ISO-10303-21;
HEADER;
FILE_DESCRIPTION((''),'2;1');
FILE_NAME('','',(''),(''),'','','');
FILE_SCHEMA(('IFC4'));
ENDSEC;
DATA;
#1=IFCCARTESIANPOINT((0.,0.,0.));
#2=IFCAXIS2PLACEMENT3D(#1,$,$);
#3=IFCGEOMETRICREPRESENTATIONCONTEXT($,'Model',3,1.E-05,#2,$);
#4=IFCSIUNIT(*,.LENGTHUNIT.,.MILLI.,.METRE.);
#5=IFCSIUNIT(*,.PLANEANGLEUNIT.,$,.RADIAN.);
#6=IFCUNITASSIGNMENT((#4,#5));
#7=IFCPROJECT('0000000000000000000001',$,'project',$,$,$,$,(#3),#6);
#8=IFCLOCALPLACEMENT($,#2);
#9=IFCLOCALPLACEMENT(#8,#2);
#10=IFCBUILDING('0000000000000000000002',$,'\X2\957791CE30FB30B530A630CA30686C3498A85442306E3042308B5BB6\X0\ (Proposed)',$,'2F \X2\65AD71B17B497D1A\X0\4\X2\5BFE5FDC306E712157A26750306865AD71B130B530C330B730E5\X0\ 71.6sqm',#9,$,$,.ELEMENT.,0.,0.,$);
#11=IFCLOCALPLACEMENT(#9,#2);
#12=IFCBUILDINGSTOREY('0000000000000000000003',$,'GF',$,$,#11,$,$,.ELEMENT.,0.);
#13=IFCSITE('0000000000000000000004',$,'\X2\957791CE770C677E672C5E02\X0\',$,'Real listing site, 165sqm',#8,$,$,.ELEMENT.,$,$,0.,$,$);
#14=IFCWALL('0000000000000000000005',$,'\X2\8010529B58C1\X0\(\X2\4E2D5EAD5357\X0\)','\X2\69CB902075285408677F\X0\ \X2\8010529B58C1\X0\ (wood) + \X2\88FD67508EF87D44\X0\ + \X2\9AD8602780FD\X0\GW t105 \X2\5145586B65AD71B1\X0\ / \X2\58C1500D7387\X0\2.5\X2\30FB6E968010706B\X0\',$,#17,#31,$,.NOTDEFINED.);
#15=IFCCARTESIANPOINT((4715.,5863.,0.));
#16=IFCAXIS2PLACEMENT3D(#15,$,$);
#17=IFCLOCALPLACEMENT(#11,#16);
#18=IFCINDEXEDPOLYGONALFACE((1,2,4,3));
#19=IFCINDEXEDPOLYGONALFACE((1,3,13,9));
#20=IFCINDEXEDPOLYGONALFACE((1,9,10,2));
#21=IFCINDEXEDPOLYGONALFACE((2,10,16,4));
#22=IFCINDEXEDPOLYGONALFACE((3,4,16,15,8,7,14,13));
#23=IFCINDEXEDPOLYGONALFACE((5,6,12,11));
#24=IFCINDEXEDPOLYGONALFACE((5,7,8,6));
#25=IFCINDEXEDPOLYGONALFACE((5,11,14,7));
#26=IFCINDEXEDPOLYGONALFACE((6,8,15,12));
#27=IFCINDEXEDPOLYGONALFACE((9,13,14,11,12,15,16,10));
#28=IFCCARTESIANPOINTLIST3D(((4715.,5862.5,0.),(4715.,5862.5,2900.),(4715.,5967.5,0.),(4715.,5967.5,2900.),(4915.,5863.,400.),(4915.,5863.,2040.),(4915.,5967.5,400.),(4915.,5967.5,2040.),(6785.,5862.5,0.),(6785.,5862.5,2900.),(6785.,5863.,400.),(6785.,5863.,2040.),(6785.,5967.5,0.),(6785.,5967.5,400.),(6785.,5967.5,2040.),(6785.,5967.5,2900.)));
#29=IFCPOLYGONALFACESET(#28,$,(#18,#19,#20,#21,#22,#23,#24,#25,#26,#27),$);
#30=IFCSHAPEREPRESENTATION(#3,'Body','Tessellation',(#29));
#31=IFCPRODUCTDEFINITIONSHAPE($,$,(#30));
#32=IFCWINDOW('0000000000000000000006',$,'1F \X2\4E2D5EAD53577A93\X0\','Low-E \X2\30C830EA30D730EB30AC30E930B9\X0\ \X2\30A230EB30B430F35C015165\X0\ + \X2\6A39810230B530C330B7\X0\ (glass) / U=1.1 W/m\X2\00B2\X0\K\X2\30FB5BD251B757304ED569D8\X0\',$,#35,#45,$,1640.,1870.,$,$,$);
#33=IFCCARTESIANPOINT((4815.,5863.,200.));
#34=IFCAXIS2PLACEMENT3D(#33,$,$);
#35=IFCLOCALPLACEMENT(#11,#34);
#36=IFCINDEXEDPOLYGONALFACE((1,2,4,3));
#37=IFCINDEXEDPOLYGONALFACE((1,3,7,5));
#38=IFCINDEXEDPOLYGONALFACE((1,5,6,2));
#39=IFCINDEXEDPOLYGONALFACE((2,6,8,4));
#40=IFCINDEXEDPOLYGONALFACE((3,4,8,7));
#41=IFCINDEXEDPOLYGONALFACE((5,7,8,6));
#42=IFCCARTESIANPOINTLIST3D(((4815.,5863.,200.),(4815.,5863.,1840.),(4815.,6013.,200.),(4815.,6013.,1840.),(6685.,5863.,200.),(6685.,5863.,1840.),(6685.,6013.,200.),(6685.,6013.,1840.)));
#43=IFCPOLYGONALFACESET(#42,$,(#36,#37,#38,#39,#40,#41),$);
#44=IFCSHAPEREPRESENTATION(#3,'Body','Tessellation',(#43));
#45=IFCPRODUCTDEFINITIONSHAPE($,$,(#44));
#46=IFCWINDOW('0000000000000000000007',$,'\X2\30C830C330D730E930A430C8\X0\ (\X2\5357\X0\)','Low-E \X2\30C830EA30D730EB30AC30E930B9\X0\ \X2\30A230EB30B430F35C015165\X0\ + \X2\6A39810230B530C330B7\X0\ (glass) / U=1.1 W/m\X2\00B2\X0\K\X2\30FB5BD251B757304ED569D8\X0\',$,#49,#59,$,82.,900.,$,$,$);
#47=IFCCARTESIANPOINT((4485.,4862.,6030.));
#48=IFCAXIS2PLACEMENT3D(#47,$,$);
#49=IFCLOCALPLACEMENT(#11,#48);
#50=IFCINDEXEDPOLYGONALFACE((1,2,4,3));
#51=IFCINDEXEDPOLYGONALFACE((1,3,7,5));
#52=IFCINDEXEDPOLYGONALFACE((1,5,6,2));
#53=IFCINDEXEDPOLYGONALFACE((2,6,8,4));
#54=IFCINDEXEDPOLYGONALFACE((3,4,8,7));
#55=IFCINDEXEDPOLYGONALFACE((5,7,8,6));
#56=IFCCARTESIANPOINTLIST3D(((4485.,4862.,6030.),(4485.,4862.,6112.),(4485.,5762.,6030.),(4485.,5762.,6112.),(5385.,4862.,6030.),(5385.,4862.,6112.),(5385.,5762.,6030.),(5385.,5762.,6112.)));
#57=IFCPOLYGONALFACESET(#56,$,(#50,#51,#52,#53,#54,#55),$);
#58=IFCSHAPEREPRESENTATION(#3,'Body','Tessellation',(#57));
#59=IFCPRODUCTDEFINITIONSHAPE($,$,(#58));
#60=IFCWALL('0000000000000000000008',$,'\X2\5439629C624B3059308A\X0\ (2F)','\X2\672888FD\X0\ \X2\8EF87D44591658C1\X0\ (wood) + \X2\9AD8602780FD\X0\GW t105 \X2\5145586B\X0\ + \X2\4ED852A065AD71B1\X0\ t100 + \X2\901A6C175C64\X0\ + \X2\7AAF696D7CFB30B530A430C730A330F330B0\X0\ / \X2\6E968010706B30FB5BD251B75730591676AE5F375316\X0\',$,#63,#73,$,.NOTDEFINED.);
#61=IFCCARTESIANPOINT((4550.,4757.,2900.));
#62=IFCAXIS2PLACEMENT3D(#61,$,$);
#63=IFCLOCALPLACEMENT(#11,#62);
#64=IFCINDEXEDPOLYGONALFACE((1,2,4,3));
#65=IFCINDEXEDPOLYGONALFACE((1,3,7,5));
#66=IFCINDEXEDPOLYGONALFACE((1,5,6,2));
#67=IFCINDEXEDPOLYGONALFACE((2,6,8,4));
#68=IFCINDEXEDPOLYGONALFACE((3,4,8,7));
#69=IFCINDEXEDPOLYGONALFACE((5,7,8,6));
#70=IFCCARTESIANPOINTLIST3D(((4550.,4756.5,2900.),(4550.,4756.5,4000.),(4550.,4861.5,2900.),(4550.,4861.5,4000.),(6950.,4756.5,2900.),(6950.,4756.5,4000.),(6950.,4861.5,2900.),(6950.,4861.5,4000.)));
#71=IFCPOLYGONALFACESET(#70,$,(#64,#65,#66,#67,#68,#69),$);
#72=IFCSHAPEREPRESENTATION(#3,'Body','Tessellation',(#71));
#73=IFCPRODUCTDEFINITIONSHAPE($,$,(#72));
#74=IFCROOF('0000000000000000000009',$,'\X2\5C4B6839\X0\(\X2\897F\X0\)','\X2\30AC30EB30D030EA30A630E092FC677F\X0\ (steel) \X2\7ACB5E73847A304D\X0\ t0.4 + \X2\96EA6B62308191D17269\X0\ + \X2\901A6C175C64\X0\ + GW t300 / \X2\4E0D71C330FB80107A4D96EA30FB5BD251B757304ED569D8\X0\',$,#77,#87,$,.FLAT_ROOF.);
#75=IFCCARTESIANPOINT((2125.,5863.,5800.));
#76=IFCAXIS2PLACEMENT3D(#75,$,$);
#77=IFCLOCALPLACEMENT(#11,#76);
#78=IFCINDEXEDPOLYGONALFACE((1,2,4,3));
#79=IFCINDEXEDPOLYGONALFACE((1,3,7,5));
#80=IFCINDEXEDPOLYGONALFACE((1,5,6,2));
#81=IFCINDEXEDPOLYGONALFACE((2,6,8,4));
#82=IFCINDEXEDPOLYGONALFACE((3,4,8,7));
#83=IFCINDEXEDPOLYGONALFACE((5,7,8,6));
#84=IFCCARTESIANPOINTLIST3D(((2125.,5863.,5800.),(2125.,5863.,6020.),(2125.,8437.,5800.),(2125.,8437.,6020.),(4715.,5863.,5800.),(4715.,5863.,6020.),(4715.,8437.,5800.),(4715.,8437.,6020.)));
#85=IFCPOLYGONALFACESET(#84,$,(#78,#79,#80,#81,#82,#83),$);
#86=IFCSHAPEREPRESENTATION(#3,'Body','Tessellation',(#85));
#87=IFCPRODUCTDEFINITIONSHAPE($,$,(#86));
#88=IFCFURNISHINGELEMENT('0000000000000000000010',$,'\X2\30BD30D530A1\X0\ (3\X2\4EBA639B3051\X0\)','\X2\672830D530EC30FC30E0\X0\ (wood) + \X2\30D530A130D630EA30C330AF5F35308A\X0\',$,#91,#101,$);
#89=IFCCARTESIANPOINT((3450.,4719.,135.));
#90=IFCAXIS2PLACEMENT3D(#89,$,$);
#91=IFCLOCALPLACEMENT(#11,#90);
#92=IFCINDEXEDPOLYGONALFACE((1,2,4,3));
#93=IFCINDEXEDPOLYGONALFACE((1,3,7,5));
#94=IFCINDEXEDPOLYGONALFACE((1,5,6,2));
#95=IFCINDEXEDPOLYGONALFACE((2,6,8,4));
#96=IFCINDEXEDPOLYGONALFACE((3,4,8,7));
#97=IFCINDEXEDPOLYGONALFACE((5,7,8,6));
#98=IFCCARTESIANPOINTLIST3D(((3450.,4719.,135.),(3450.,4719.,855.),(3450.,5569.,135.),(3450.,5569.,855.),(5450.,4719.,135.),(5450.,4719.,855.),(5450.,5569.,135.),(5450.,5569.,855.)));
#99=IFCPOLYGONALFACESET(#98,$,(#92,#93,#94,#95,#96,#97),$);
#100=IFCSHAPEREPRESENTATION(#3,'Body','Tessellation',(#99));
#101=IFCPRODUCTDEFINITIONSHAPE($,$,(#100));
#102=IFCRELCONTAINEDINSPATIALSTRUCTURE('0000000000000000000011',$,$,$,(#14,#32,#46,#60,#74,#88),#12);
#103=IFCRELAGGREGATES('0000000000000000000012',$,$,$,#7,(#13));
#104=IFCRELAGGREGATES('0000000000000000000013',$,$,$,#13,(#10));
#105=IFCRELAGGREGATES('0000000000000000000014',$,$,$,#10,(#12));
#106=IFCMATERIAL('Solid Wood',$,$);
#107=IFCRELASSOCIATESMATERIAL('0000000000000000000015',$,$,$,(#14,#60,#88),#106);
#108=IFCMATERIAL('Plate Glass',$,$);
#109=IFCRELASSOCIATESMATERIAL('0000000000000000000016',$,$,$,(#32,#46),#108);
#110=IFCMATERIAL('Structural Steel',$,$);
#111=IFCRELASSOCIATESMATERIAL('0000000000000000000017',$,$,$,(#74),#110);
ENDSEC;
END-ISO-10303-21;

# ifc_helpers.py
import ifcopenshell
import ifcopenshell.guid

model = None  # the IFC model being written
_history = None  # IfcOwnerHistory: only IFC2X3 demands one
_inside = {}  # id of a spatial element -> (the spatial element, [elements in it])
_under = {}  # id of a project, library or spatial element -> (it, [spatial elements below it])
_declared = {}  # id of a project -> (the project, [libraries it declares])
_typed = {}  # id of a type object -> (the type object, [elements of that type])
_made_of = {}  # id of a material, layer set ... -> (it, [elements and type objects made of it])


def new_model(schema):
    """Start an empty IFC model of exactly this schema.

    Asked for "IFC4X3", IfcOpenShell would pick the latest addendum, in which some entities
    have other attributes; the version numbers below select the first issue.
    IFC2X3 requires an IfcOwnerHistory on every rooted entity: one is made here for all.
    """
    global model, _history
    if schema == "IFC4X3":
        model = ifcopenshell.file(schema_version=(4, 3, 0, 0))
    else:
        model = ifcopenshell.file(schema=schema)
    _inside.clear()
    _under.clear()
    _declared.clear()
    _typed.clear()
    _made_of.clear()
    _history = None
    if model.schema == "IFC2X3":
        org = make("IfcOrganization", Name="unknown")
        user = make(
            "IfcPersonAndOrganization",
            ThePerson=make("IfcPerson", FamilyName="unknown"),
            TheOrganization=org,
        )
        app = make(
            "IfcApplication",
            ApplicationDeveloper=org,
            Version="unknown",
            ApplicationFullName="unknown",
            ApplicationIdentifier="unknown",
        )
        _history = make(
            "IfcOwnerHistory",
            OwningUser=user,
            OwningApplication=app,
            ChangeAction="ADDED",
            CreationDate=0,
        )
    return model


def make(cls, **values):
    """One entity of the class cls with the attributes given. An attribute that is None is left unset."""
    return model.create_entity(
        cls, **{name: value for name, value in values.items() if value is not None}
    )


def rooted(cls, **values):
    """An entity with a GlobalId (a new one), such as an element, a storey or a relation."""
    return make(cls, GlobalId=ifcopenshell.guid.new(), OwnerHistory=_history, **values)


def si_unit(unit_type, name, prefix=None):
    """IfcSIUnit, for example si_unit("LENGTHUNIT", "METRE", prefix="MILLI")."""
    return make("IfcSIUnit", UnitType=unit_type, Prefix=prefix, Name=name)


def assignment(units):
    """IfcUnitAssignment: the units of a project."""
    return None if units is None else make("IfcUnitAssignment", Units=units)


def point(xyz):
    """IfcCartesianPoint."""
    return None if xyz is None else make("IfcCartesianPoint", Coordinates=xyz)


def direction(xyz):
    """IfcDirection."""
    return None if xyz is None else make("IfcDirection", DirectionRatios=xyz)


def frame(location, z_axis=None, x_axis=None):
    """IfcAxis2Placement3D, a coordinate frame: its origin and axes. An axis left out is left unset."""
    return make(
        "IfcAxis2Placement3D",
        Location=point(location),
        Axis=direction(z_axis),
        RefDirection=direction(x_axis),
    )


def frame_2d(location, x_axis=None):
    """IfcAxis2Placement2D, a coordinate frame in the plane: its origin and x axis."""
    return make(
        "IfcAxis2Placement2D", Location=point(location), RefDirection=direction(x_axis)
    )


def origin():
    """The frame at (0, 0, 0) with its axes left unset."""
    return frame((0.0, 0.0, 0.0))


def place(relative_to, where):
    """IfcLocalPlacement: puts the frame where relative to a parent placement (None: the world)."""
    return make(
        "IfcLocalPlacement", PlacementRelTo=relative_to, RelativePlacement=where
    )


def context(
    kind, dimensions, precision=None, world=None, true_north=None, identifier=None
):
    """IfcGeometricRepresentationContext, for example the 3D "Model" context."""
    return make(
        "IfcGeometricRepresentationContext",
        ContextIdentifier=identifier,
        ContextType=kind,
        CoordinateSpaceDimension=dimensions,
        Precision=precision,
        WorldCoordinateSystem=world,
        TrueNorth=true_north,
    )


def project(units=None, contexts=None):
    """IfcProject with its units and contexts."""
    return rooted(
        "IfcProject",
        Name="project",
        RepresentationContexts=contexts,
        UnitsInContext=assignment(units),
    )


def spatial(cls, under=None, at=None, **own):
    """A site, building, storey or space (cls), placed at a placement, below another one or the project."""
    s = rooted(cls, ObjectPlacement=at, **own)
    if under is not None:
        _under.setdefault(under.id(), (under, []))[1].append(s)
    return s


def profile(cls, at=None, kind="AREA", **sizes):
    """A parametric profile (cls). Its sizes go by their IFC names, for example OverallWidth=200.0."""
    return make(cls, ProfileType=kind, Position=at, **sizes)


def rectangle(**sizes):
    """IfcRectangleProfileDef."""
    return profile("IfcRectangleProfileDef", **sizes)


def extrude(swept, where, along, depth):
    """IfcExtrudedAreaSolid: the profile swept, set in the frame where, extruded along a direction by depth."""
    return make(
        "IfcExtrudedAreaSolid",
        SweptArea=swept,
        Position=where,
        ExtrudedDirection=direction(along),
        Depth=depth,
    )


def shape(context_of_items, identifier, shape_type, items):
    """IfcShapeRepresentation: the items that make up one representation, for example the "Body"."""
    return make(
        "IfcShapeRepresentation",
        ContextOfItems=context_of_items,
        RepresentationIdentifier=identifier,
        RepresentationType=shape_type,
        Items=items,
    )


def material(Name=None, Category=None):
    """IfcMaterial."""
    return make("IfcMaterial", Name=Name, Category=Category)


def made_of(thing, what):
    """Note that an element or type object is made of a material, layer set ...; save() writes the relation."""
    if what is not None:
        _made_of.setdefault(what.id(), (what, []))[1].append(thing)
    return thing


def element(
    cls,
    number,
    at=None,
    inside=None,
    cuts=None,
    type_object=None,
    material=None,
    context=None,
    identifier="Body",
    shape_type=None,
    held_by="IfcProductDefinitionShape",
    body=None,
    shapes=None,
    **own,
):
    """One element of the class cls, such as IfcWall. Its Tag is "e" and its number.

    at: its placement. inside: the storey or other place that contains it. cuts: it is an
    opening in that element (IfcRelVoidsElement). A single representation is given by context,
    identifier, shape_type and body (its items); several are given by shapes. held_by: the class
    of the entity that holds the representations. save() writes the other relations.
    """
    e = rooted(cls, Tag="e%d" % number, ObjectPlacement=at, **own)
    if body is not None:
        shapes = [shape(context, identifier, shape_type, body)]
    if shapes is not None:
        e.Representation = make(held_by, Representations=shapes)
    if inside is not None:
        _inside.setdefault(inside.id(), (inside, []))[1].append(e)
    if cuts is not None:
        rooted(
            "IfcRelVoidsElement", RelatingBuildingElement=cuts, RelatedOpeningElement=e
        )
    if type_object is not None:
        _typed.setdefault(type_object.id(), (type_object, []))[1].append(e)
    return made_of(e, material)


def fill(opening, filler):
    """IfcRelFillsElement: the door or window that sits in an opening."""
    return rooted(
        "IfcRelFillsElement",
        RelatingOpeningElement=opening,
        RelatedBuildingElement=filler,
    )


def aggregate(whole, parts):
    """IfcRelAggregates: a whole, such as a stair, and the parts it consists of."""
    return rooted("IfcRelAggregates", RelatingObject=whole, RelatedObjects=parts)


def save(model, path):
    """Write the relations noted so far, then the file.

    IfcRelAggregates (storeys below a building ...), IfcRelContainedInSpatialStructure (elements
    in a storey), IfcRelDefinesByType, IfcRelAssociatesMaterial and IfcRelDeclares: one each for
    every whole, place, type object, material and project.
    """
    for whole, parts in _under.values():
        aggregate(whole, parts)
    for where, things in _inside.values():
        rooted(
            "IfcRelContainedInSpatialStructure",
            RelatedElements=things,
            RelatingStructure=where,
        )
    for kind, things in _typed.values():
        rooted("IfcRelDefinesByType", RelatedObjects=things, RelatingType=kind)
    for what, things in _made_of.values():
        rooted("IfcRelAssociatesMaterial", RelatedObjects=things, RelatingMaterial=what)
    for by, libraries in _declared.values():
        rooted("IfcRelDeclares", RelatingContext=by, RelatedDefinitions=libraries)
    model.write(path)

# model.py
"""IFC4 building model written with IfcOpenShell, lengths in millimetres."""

from ifc_helpers import new_model, si_unit, frame, frame_2d, origin, place, context, project, spatial, rectangle, extrude, material, element, fill, save


model = new_model("IFC4")

# Units and contexts
model_context = context("Model", 3, precision=1e-05, world=origin())
ifc_project = project(units=[si_unit("LENGTHUNIT", "METRE", prefix="MILLI"), si_unit("PLANEANGLEUNIT", "RADIAN")], contexts=[model_context])

# Site, building, storey
site_placement = place(None, origin())
site = spatial("IfcSite", under=ifc_project, at=site_placement, Name="長野県松本市", ObjectType="Real listing site, 165sqm", CompositionType="ELEMENT", RefElevation=0.0)
building_placement = place(site_placement, origin())
building = spatial("IfcBuilding", under=site, at=building_placement, Name="長野・サウナと水風呂のある家 (Proposed)", ObjectType="2F 断熱等級4対応の無垢材と断熱サッシュ 71.6sqm", CompositionType="ELEMENT", ElevationOfRefHeight=0.0, ElevationOfTerrain=0.0)
storey_placement = place(building_placement, origin())
storey = spatial("IfcBuildingStorey", under=building, at=storey_placement, Name="GF", CompositionType="ELEMENT", Elevation=0.0)

# Shared definitions
ifc_material_1 = material(Name="Solid Wood")

# Wall, opening, window
wall_1_placement = place(storey_placement, frame((4715.0, 5863.0, 0.0)))
wall_1 = element("IfcWall", 1, at=wall_1_placement, inside=storey, material=ifc_material_1, Name="耐力壁(中庭南)", Description="構造用合板 耐力壁 (wood) + 製材軸組 + 高性能GW t105 充填断熱 / 壁倍率2.5・準耐火", PredefinedType="NOTDEFINED", context=model_context, shape_type="SweptSolid", body=[
    extrude(rectangle(XDim=2070.0, YDim=105.0, at=frame_2d((1035.0, 52.0))), frame((4715.0, 5863.0, 0.0)), (0.0, 0.0, 1.0), 2900.0),
])
opening_placement = place(storey_placement, frame((4815.0, 5863.0, 200.0)))
opening = element("IfcOpeningElement", 2, at=opening_placement, cuts=wall_1, PredefinedType="NOTDEFINED", context=model_context, shape_type="SweptSolid", body=[
    extrude(rectangle(XDim=1870.0, YDim=150.0, at=frame_2d((935.0, 75.0))), frame((4815.0, 5863.0, 200.0)), (0.0, 0.0, 1.0), 1640.0),
])
ifc_material_2 = material(Name="Plate Glass")
window_1_placement = place(storey_placement, frame((4815.0, 5863.0, 200.0)))
window_1 = element("IfcWindow", 3, at=window_1_placement, inside=storey, material=ifc_material_2, Name="1F 中庭南窓", Description="Low-E トリプルガラス アルゴン封入 + 樹脂サッシ (glass) / U=1.1 W/m²K・寒冷地仕様", OverallHeight=1640.0, OverallWidth=1870.0, context=model_context, shape_type="SweptSolid", body=[
    extrude(rectangle(XDim=1870.0, YDim=150.0, at=frame_2d((935.0, 75.0))), frame((4815.0, 5863.0, 200.0)), (0.0, 0.0, 1.0), 1640.0),
])
fill(opening, window_1)

# Window
window_2_placement = place(storey_placement, frame((4485.0, 4862.0, 6030.0)))
element("IfcWindow", 4, at=window_2_placement, inside=storey, material=ifc_material_2, Name="トップライト (南)", Description="Low-E トリプルガラス アルゴン封入 + 樹脂サッシ (glass) / U=1.1 W/m²K・寒冷地仕様", OverallHeight=82.0, OverallWidth=900.0, context=model_context, shape_type="SweptSolid", body=[
    extrude(rectangle(XDim=900.0, YDim=900.0, at=frame_2d((450.0, 450.0))), frame((4485.0, 4862.0, 6030.0)), (0.0, 0.0, 1.0), 82.0),
])

# Wall
wall_2_placement = place(storey_placement, frame((4550.0, 4757.0, 2900.0)))
element("IfcWall", 5, at=wall_2_placement, inside=storey, material=ifc_material_1, Name="吹抜手すり (2F)", Description="木製 軸組外壁 (wood) + 高性能GW t105 充填 + 付加断熱 t100 + 通気層 + 窯業系サイディング / 準耐火・寒冷地外皮強化", PredefinedType="NOTDEFINED", context=model_context, shape_type="SweptSolid", body=[
    extrude(rectangle(XDim=2400.0, YDim=105.0, at=frame_2d((1200.0, 52.0))), frame((4550.0, 4757.0, 2900.0)), (0.0, 0.0, 1.0), 1100.0),
])

# Roof
ifc_material_3 = material(Name="Structural Steel")
for number, where, name in (
    (6, (2125.0, 5863.0, 5800.0), "屋根(西)"),
):
    element("IfcRoof", number, at=place(storey_placement, frame(where)), inside=storey, material=ifc_material_3, Name=name, Description="ガルバリウム鋼板 (steel) 立平葺き t0.4 + 雪止め金物 + 通気層 + GW t300 / 不燃・耐積雪・寒冷地仕様", PredefinedType="FLAT_ROOF", context=model_context, shape_type="SweptSolid", body=[
        extrude(rectangle(XDim=2590.0, YDim=2574.0, at=frame_2d((1295.0, 1287.0))), frame((2125.0, 5863.0, 5800.0)), (0.0, 0.0, 1.0), 220.0),
    ])

# Furnishing element
furnishing_placement = place(storey_placement, frame((3450.0, 4719.0, 135.0)))
element("IfcFurnishingElement", 7, at=furnishing_placement, inside=storey, material=ifc_material_1, Name="ソファ (3人掛け)", Description="木フレーム (wood) + ファブリック張り", context=model_context, shape_type="SweptSolid", body=[
    extrude(rectangle(XDim=2000.0, YDim=850.0, at=frame_2d((1000.0, 425.0))), frame((3450.0, 4719.0, 135.0)), (0.0, 0.0, 1.0), 720.0),
])

save(model, "model.ifc")
